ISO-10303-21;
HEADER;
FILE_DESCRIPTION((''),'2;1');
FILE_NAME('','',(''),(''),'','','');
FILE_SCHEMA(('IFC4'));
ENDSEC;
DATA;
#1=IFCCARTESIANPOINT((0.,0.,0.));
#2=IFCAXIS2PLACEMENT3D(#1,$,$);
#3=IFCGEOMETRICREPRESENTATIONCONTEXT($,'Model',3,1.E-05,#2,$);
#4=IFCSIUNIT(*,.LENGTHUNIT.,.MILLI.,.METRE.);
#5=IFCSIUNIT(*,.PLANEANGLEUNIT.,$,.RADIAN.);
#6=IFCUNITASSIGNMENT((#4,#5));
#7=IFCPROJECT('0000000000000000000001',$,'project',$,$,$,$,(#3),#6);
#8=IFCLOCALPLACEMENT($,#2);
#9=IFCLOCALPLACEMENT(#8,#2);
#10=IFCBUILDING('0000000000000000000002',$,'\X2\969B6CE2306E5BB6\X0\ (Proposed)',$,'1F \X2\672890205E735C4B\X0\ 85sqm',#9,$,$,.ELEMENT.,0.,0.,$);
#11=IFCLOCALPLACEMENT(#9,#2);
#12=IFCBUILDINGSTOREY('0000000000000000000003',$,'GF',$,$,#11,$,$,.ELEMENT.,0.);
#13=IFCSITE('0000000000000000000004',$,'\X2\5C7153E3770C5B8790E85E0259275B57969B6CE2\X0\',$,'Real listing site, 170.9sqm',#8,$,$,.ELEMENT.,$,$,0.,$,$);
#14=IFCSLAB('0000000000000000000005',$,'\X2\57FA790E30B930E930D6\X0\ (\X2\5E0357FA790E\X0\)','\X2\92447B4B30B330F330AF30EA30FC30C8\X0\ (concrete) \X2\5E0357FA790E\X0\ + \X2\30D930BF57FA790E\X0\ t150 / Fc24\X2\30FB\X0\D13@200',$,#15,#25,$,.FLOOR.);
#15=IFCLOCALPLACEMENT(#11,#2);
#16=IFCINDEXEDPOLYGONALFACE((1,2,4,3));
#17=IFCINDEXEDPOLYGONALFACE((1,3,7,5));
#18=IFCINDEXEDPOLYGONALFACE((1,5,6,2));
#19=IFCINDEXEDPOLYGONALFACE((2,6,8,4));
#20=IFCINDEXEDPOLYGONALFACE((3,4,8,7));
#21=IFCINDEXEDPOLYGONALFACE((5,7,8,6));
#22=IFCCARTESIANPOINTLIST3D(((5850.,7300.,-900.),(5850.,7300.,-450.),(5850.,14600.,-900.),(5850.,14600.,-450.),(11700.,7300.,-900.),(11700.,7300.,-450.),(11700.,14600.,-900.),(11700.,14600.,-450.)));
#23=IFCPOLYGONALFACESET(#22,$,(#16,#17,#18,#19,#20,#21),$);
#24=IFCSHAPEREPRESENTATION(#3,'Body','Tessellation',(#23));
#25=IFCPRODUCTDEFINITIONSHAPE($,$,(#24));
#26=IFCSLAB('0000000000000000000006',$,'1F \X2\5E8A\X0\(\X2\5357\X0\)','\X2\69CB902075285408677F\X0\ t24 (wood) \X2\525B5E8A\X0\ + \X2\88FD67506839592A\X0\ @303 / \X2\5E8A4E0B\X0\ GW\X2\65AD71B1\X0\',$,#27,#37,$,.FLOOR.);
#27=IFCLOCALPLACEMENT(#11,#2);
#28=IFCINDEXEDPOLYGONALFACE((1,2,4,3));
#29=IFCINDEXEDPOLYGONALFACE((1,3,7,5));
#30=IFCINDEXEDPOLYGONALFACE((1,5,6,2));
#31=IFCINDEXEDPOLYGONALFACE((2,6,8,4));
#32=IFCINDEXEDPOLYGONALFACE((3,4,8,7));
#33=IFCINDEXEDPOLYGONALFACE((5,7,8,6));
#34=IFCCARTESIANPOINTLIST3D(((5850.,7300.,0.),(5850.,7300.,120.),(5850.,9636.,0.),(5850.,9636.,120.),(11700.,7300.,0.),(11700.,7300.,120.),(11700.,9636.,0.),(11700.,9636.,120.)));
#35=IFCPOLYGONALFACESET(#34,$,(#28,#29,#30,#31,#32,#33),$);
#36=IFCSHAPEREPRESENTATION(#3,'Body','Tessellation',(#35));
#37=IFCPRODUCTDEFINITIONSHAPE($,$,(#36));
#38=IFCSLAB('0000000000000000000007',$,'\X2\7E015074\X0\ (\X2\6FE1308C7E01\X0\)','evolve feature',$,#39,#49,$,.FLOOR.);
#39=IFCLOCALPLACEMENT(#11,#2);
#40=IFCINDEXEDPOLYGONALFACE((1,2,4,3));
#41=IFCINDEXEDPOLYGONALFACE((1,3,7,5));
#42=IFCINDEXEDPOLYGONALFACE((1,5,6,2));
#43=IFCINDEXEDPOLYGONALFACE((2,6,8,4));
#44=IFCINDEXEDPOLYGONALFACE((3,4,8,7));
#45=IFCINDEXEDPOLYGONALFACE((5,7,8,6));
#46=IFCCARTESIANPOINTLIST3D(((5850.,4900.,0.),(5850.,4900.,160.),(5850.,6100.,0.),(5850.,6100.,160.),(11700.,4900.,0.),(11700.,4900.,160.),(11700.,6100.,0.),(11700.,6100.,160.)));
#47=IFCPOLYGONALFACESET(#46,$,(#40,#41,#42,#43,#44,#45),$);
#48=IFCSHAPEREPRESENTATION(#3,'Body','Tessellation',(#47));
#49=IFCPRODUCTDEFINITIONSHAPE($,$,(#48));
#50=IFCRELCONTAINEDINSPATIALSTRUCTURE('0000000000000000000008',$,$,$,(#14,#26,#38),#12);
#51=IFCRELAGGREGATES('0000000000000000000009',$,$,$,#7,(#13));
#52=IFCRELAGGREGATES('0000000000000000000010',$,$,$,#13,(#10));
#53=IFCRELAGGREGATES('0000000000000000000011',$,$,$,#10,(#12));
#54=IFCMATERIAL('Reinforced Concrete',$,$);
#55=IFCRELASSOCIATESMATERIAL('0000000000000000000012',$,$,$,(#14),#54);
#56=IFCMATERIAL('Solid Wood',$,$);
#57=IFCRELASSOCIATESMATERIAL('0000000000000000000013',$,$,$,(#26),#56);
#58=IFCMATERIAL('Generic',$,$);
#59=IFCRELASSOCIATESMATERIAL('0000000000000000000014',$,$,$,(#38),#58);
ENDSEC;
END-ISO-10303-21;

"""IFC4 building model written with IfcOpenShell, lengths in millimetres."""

from ifc_helpers import new_model, si_unit, frame, frame_2d, origin, place, context, project, spatial, rectangle, extrude, material, element, save


model = new_model("IFC4")

# Units and contexts
model_context = context("Model", 3, precision=1e-05, world=origin())
ifc_project = project(units=[si_unit("LENGTHUNIT", "METRE", prefix="MILLI"), si_unit("PLANEANGLEUNIT", "RADIAN")], contexts=[model_context])

# Site, building, storey
site_placement = place(None, origin())
site = spatial("IfcSite", under=ifc_project, at=site_placement, Name="山口県宇部市大字際波", ObjectType="Real listing site, 170.9sqm", CompositionType="ELEMENT", RefElevation=0.0)
building_placement = place(site_placement, origin())
building = spatial("IfcBuilding", under=site, at=building_placement, Name="際波の家 (Proposed)", ObjectType="1F 木造平屋 85sqm", CompositionType="ELEMENT", ElevationOfRefHeight=0.0, ElevationOfTerrain=0.0)
storey_placement = place(building_placement, origin())
storey = spatial("IfcBuildingStorey", under=building, at=storey_placement, Name="GF", CompositionType="ELEMENT", Elevation=0.0)

# Slabs
ifc_material_1 = material(Name="Reinforced Concrete")
slab_1_placement = place(storey_placement, frame((2925.0, 3650.0, -450.0)))
element("IfcSlab", 1, at=slab_1_placement, inside=storey, material=ifc_material_1, Name="基礎スラブ (布基礎)", Description="鉄筋コンクリート (concrete) 布基礎 + ベタ基礎 t150 / Fc24・D13@200", PredefinedType="FLOOR", context=model_context, shape_type="SweptSolid", body=[
    extrude(rectangle(XDim=5850.0, YDim=7300.0, at=frame_2d((2925.0, 3650.0))), frame((2925.0, 3650.0, -450.0)), (0.0, 0.0, 1.0), 450.0),
])
ifc_material_2 = material(Name="Solid Wood")
slab_2_placement = place(storey_placement, frame((2925.0, 3650.0, 0.0)))
element("IfcSlab", 2, at=slab_2_placement, inside=storey, material=ifc_material_2, Name="1F 床(南)", Description="構造用合板 t24 (wood) 剛床 + 製材根太 @303 / 床下 GW断熱", PredefinedType="FLOOR", context=model_context, shape_type="SweptSolid", body=[
    extrude(rectangle(XDim=5850.0, YDim=2336.0, at=frame_2d((2925.0, 1168.0))), frame((2925.0, 3650.0, 0.0)), (0.0, 0.0, 1.0), 120.0),
])
ifc_material_3 = material(Name="Generic")
slab_3_placement = place(storey_placement, frame((2925.0, 2450.0, 0.0)))
element("IfcSlab", 3, at=slab_3_placement, inside=storey, material=ifc_material_3, Name="縁側 (濡れ縁)", Description="evolve feature", PredefinedType="FLOOR", context=model_context, shape_type="SweptSolid", body=[
    extrude(rectangle(XDim=5850.0, YDim=1200.0, at=frame_2d((2925.0, 600.0))), frame((2925.0, 2450.0, 0.0)), (0.0, 0.0, 1.0), 160.0),
])

save(model, "model.ifc")
